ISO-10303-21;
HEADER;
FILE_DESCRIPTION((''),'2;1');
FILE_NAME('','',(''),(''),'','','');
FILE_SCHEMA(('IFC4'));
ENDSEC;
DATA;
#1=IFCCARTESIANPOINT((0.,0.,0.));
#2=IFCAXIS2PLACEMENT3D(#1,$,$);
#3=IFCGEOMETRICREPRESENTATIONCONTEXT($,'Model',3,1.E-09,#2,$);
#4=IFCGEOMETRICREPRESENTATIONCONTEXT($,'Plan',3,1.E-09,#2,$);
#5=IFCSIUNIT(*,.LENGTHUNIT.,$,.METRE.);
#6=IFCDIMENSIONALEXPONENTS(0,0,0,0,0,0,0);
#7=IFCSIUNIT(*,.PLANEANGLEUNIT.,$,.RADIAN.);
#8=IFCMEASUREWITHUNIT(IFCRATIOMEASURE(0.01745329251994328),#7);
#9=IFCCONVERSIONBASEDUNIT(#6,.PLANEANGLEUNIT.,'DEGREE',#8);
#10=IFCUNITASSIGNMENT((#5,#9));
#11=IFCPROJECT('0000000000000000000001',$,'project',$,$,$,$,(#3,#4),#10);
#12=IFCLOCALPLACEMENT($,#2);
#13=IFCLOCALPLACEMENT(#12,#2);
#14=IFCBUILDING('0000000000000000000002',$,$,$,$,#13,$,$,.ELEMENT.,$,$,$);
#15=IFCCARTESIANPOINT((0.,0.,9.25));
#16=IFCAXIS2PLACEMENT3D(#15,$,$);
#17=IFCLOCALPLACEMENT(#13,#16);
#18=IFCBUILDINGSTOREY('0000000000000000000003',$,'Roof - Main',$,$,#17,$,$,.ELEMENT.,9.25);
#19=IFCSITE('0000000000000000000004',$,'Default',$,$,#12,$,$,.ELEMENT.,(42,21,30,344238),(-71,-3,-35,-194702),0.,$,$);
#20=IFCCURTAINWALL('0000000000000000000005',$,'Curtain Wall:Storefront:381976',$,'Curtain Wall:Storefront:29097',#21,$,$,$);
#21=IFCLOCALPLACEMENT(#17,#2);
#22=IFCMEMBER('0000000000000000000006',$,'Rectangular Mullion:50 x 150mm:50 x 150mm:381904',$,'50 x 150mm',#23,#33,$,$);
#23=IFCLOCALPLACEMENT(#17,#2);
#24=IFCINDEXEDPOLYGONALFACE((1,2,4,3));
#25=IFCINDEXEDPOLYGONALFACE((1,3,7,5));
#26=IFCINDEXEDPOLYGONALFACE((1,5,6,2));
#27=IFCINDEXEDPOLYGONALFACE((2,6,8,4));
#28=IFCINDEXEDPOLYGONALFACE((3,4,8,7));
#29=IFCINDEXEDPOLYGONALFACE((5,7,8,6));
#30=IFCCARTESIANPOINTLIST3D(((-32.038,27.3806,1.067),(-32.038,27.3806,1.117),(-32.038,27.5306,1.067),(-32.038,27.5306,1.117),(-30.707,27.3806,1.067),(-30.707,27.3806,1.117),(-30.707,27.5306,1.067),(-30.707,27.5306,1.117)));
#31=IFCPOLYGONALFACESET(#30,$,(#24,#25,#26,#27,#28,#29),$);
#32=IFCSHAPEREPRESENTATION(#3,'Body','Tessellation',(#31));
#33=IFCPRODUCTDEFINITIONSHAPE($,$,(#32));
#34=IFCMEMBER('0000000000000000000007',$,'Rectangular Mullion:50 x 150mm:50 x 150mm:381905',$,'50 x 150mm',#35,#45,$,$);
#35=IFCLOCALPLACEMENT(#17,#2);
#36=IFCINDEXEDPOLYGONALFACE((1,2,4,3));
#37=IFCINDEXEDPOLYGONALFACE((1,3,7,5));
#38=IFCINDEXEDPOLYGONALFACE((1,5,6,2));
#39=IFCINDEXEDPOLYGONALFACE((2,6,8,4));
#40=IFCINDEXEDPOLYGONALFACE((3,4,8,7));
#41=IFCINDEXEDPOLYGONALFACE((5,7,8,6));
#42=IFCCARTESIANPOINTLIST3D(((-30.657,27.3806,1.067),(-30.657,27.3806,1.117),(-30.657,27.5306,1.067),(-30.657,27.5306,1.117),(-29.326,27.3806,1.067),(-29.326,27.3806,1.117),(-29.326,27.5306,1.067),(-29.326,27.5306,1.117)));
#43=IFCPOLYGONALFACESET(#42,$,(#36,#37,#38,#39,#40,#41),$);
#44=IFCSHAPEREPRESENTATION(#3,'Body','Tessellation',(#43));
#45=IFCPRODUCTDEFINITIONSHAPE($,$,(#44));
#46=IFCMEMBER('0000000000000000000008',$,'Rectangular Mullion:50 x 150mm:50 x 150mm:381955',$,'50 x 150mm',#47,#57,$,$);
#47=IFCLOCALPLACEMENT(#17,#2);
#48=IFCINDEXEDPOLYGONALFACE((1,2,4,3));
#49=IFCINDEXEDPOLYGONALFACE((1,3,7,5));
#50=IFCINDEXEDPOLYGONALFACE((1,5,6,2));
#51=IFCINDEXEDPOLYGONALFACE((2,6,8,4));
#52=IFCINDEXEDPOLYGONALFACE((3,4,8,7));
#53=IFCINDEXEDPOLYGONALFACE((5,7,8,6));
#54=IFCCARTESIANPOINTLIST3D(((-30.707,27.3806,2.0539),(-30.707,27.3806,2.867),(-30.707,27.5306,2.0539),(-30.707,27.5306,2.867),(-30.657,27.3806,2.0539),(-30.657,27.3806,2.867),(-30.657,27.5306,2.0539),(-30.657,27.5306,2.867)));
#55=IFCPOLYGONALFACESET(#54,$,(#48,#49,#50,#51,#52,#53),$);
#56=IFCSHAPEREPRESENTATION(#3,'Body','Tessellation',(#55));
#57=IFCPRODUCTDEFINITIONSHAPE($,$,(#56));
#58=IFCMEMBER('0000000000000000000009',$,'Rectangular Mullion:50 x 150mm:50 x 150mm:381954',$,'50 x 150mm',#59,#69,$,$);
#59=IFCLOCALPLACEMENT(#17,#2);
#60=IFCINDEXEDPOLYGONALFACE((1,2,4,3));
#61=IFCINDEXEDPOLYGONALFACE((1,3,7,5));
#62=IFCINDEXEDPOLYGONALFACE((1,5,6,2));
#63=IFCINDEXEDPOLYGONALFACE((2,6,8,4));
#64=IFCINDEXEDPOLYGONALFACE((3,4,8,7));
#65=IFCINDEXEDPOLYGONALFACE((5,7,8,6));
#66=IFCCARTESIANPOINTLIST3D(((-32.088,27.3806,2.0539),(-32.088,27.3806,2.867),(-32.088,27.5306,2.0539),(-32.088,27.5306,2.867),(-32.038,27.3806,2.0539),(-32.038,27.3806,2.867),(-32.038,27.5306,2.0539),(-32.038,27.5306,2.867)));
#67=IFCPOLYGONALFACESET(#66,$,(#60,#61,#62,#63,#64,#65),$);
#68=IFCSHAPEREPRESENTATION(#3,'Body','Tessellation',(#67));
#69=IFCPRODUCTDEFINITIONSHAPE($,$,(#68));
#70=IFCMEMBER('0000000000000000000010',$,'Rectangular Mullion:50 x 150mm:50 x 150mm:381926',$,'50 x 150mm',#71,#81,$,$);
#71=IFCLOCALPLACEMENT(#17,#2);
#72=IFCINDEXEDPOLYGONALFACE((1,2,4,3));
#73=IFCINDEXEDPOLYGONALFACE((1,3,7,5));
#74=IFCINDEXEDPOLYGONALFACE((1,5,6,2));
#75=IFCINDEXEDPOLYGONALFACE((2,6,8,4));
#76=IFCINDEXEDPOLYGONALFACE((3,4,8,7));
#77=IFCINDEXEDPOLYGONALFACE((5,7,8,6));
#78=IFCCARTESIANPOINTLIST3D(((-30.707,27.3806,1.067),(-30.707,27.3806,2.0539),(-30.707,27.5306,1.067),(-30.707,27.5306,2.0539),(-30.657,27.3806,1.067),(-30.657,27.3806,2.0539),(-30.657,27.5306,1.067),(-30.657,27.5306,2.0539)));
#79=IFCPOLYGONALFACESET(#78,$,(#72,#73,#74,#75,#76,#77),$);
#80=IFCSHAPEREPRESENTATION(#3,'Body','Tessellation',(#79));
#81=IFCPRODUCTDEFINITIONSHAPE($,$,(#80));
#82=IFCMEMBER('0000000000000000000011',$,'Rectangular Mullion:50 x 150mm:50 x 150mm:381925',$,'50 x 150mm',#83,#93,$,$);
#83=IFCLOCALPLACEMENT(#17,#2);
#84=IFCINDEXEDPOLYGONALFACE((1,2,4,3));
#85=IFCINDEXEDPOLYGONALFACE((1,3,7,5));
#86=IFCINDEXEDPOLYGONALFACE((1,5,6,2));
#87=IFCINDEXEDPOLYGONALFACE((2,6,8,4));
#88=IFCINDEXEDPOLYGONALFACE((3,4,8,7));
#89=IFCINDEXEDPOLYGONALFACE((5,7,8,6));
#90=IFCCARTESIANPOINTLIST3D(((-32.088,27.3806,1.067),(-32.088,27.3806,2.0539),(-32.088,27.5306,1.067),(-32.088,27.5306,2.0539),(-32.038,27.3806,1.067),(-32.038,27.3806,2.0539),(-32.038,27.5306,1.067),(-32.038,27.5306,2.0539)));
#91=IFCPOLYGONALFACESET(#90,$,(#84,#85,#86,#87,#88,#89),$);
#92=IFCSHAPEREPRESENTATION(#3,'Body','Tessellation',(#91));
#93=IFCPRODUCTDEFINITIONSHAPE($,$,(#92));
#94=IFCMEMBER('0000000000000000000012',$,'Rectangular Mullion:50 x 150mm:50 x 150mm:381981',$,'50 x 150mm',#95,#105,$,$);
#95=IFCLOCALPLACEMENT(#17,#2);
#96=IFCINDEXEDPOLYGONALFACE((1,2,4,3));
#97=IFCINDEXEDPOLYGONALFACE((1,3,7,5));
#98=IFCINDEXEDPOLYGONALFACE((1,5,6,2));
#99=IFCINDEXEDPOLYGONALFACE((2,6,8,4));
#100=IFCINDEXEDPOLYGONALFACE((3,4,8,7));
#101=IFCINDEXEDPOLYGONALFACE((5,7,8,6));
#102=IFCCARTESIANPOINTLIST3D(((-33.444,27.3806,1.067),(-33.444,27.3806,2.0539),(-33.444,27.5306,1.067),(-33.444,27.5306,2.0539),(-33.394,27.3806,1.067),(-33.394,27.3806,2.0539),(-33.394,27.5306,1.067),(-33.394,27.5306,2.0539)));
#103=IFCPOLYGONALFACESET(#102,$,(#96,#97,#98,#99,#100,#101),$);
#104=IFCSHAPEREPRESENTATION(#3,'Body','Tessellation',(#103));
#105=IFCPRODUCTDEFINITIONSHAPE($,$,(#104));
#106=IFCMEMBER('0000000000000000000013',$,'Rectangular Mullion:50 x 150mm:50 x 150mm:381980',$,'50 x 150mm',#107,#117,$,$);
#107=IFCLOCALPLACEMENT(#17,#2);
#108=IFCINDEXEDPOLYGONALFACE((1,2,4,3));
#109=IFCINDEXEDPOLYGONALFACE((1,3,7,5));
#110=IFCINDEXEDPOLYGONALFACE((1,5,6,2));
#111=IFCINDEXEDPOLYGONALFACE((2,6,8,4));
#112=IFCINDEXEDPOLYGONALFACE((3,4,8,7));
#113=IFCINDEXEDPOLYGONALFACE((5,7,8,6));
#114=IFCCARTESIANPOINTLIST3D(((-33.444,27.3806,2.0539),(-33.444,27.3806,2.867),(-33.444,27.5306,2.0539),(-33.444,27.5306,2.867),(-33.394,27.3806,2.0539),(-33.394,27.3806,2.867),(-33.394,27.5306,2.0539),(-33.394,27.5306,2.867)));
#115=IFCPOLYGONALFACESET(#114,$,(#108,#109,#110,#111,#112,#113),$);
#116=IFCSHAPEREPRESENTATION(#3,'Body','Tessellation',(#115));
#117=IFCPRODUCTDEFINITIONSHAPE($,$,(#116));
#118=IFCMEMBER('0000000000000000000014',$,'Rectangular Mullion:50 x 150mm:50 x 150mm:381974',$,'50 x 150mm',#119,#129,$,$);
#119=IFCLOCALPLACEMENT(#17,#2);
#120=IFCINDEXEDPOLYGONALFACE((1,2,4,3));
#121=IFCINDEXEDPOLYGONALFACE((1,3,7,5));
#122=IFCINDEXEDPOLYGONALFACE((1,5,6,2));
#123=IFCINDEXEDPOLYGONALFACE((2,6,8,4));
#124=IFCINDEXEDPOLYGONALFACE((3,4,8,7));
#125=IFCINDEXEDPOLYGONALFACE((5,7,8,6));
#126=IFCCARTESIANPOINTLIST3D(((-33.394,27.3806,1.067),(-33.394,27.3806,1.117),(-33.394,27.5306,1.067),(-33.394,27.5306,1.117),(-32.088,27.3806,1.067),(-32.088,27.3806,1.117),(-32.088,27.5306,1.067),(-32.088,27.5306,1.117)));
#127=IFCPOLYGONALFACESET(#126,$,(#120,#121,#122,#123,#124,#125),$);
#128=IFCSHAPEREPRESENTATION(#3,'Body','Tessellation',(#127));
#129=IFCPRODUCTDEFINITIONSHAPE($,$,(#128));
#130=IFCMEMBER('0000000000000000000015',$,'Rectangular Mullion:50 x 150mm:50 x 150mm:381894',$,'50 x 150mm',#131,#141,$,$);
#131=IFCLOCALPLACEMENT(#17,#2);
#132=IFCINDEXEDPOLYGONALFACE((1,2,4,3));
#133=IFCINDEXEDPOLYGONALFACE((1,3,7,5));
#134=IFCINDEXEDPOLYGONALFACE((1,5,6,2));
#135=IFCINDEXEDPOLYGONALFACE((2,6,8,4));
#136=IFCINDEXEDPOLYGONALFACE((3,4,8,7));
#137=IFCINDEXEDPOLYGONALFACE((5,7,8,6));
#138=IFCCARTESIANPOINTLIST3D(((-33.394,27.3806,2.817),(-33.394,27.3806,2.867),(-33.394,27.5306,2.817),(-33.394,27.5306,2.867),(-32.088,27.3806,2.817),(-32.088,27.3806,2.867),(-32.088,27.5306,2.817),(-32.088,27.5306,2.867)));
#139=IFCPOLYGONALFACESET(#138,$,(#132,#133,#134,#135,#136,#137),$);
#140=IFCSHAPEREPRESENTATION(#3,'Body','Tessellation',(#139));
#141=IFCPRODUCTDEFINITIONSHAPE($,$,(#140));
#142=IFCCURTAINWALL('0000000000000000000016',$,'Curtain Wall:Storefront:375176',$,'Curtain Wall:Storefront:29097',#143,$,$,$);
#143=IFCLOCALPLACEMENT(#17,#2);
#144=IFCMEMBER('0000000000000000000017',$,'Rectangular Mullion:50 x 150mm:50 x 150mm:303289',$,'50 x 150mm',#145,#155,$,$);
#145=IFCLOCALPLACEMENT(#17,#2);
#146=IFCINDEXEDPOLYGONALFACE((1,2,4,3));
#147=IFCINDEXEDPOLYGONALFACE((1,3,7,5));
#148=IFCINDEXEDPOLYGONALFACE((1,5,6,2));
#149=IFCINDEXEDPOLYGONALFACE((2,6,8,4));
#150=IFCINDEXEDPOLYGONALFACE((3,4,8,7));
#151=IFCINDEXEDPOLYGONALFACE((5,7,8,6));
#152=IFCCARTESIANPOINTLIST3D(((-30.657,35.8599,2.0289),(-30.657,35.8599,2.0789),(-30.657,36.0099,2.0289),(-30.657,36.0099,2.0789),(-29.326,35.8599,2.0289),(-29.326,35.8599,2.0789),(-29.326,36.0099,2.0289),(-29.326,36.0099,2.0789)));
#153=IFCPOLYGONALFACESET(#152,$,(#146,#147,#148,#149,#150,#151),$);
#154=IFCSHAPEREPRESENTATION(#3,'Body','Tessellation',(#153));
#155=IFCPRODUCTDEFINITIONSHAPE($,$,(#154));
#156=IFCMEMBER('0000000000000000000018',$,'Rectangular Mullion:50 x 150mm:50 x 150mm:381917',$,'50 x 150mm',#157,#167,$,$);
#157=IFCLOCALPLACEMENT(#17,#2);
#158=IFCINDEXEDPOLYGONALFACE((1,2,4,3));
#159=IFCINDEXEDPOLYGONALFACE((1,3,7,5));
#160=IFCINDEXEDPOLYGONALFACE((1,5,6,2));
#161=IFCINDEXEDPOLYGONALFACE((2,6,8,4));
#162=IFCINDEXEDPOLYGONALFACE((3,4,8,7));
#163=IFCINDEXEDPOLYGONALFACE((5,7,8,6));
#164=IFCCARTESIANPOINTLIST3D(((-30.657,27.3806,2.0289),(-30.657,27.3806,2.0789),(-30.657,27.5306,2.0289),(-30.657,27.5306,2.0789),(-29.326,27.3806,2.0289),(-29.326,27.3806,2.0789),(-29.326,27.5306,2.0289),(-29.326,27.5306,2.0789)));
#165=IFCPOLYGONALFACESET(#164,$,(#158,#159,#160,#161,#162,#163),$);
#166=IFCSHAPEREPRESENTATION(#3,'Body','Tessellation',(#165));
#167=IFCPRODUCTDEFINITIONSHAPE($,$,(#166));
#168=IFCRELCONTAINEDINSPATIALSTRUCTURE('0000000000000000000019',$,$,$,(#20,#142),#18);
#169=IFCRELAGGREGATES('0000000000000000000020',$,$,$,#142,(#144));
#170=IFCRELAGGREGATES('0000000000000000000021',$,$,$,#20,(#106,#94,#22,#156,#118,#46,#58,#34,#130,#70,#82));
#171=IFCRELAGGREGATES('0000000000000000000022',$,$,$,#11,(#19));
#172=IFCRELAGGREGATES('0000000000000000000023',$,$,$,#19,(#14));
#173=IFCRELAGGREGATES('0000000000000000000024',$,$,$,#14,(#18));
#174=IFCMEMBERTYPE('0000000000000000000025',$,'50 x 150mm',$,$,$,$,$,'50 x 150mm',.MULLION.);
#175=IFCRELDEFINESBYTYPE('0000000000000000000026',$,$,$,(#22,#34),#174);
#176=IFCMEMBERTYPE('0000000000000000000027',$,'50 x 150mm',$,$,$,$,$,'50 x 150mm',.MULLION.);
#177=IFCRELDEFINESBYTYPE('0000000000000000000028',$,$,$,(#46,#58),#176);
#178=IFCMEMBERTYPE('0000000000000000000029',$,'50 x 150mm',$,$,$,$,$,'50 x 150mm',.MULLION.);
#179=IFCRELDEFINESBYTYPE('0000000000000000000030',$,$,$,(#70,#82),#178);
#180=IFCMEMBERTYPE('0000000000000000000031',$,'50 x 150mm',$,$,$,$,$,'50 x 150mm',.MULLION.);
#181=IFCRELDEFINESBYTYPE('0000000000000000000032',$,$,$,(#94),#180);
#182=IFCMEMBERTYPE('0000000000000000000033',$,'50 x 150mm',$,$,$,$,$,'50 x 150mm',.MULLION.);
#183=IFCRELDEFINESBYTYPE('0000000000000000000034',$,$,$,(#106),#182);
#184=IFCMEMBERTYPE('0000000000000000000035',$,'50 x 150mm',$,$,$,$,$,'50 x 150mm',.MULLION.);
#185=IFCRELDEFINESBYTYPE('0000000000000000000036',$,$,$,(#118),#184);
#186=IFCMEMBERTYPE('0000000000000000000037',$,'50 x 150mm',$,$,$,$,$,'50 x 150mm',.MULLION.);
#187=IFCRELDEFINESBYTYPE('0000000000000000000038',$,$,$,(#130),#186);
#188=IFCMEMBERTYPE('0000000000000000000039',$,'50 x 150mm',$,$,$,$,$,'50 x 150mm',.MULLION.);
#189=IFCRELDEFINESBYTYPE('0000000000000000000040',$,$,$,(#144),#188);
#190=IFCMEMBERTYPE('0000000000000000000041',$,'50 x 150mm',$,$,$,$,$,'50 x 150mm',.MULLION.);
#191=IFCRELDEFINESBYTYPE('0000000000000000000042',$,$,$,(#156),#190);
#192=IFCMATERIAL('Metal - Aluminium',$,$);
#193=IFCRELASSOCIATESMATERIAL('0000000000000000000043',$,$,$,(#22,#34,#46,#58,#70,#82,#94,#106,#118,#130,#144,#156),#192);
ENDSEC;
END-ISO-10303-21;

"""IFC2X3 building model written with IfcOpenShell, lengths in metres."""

from ifc_helpers import new_model, entity, si_unit, converted_unit, frame, origin, origin_2d_with_axis, place, context, project, spatial, rectangle, extrude, source, transform, mapped, material, type_object, type_shapes, element, aggregate, save


model = new_model("IFC2X3")

# Units and contexts
model_context = context("Model", 3, precision=1e-09, world=origin())
plan_context = context("Plan", 3, precision=1e-09, world=origin())
ifc_project = project(units=[si_unit("LENGTHUNIT", "METRE"), converted_unit("PLANEANGLEUNIT", "DEGREE", entity("IfcRatioMeasure", 0.01745329251994328), si_unit("PLANEANGLEUNIT", "RADIAN"), dimensions=[0, 0, 0, 0, 0, 0, 0])], contexts=[model_context, plan_context])

# Site, building, storey
site_placement = place(None, origin())
site = spatial("IfcSite", under=ifc_project, at=site_placement, Name="Default", CompositionType="ELEMENT", RefLatitude=(42, 21, 30, 344238), RefLongitude=(-71, -3, -35, -194702), RefElevation=0.0)
building_placement = place(site_placement, origin())
building = spatial("IfcBuilding", under=site, at=building_placement, CompositionType="ELEMENT")
storey_placement = place(building_placement, frame((0.0, 0.0, 9.25)))
storey = spatial("IfcBuildingStorey", under=building, at=storey_placement, Name="Roof - Main", CompositionType="ELEMENT", Elevation=9.25)

# Curtain wall, members
curtain_wall_1_placement = place(storey_placement, origin())
curtain_wall_1 = element("IfcCurtainWall", 1, at=curtain_wall_1_placement, inside=storey, Name="Curtain Wall:Storefront:381976", ObjectType="Curtain Wall:Storefront:29097")
ifc_material_1 = material(Name="Metal - Aluminium")
member_type_1 = type_object("IfcMemberType", Name="50 x 150mm", ElementType="50 x 150mm", PredefinedType="MULLION")
shared_shape_1 = source(origin(), model_context, "Body", "SweptSolid", [
    extrude(rectangle(XDim=0.05, YDim=0.15, at=origin_2d_with_axis()), frame((-0.025, 0.0, -1.331), z_axis=(0.0, 0.0, 1.0), x_axis=(-1.0, 0.0, 0.0)), (0.0, 0.0, 1.0), 1.331),
])
type_shapes(member_type_1, [shared_shape_1])
member_1_placement = place(storey_placement, frame((-32.038, 27.4556, 1.067), z_axis=(-1.0, 0.0, 0.0), x_axis=(0.0, 0.0, -1.0)))
member_1 = element("IfcMember", 2, at=member_1_placement, type_object=member_type_1, material=ifc_material_1, Name="Rectangular Mullion:50 x 150mm:50 x 150mm:381904", ObjectType="50 x 150mm", context=model_context, shape_type="MappedRepresentation", body=[
    mapped(shared_shape_1, transform((0.0, 0.0, 0.0), scale=1.0)),
])
member_2_placement = place(storey_placement, frame((-30.657, 27.4556, 1.067), z_axis=(-1.0, 0.0, 0.0), x_axis=(0.0, 0.0, -1.0)))
member_2 = element("IfcMember", 3, at=member_2_placement, type_object=member_type_1, material=ifc_material_1, Name="Rectangular Mullion:50 x 150mm:50 x 150mm:381905", ObjectType="50 x 150mm", context=model_context, shape_type="MappedRepresentation", body=[
    mapped(shared_shape_1, transform((0.0, 0.0, 0.0), scale=1.0)),
])
member_type_2 = type_object("IfcMemberType", Name="50 x 150mm", ElementType="50 x 150mm", PredefinedType="MULLION")
shared_shape_2 = source(origin(), model_context, "Body", "SweptSolid", [
    extrude(rectangle(XDim=0.05, YDim=0.15, at=origin_2d_with_axis()), frame((0.0, 0.0, -0.8131), z_axis=(0.0, 0.0, 1.0), x_axis=(-1.0, 0.0, 0.0)), (0.0, 0.0, 1.0), 0.8131),
])
type_shapes(member_type_2, [shared_shape_2])
member_3_placement = place(storey_placement, frame((-30.682, 27.4556, 2.0539), z_axis=(0.0, 0.0, -1.0), x_axis=(1.0, 0.0, 0.0)))
member_3 = element("IfcMember", 4, at=member_3_placement, type_object=member_type_2, material=ifc_material_1, Name="Rectangular Mullion:50 x 150mm:50 x 150mm:381955", ObjectType="50 x 150mm", context=model_context, shape_type="MappedRepresentation", body=[
    mapped(shared_shape_2, transform((0.0, 0.0, 0.0), scale=1.0)),
])
member_4_placement = place(storey_placement, frame((-32.063, 27.4556, 2.0539), z_axis=(0.0, 0.0, -1.0), x_axis=(1.0, 0.0, 0.0)))
member_4 = element("IfcMember", 5, at=member_4_placement, type_object=member_type_2, material=ifc_material_1, Name="Rectangular Mullion:50 x 150mm:50 x 150mm:381954", ObjectType="50 x 150mm", context=model_context, shape_type="MappedRepresentation", body=[
    mapped(shared_shape_2, transform((0.0, 0.0, 0.0), scale=1.0)),
])
member_type_3 = type_object("IfcMemberType", Name="50 x 150mm", ElementType="50 x 150mm", PredefinedType="MULLION")
shared_shape_3 = source(origin(), model_context, "Body", "SweptSolid", [
    extrude(rectangle(XDim=0.05, YDim=0.15, at=origin_2d_with_axis()), frame((0.0, 0.0, -0.9869), z_axis=(0.0, 0.0, 1.0), x_axis=(-1.0, 0.0, 0.0)), (0.0, 0.0, 1.0), 0.9869),
])
type_shapes(member_type_3, [shared_shape_3])
member_5_placement = place(storey_placement, frame((-30.682, 27.4556, 1.067), z_axis=(0.0, 0.0, -1.0), x_axis=(1.0, 0.0, 0.0)))
member_5 = element("IfcMember", 6, at=member_5_placement, type_object=member_type_3, material=ifc_material_1, Name="Rectangular Mullion:50 x 150mm:50 x 150mm:381926", ObjectType="50 x 150mm", context=model_context, shape_type="MappedRepresentation", body=[
    mapped(shared_shape_3, transform((0.0, 0.0, 0.0), scale=1.0)),
])
member_6_placement = place(storey_placement, frame((-32.063, 27.4556, 1.067), z_axis=(0.0, 0.0, -1.0), x_axis=(1.0, 0.0, 0.0)))
member_6 = element("IfcMember", 7, at=member_6_placement, type_object=member_type_3, material=ifc_material_1, Name="Rectangular Mullion:50 x 150mm:50 x 150mm:381925", ObjectType="50 x 150mm", context=model_context, shape_type="MappedRepresentation", body=[
    mapped(shared_shape_3, transform((0.0, 0.0, 0.0), scale=1.0)),
])
member_type_4 = type_object("IfcMemberType", Name="50 x 150mm", ElementType="50 x 150mm", PredefinedType="MULLION")
shared_shape_4 = source(origin(), model_context, "Body", "SweptSolid", [
    extrude(rectangle(XDim=0.05, YDim=0.15, at=origin_2d_with_axis()), frame((-0.025, 0.0, -0.9869), z_axis=(0.0, 0.0, 1.0), x_axis=(-1.0, 0.0, 0.0)), (0.0, 0.0, 1.0), 0.9869),
])
type_shapes(member_type_4, [shared_shape_4])
member_7_placement = place(storey_placement, frame((-33.444, 27.4556, 2.0539), z_axis=(0.0, 0.0, 1.0), x_axis=(-1.0, 0.0, 0.0)))
member_7 = element("IfcMember", 8, at=member_7_placement, type_object=member_type_4, material=ifc_material_1, Name="Rectangular Mullion:50 x 150mm:50 x 150mm:381981", ObjectType="50 x 150mm", context=model_context, shape_type="MappedRepresentation", body=[
    mapped(shared_shape_4, transform((0.0, 0.0, 0.0), scale=1.0)),
])
member_type_5 = type_object("IfcMemberType", Name="50 x 150mm", ElementType="50 x 150mm", PredefinedType="MULLION")
shared_shape_5 = source(origin(), model_context, "Body", "SweptSolid", [
    extrude(rectangle(XDim=0.05, YDim=0.15, at=origin_2d_with_axis()), frame((-0.025, 0.0, -0.8131), z_axis=(0.0, 0.0, 1.0), x_axis=(-1.0, 0.0, 0.0)), (0.0, 0.0, 1.0), 0.8131),
])
type_shapes(member_type_5, [shared_shape_5])
member_8_placement = place(storey_placement, frame((-33.444, 27.4556, 2.867), z_axis=(0.0, 0.0, 1.0), x_axis=(-1.0, 0.0, 0.0)))
member_8 = element("IfcMember", 9, at=member_8_placement, type_object=member_type_5, material=ifc_material_1, Name="Rectangular Mullion:50 x 150mm:50 x 150mm:381980", ObjectType="50 x 150mm", context=model_context, shape_type="MappedRepresentation", body=[
    mapped(shared_shape_5, transform((0.0, 0.0, 0.0), scale=1.0)),
])
member_type_6 = type_object("IfcMemberType", Name="50 x 150mm", ElementType="50 x 150mm", PredefinedType="MULLION")
shared_shape_6 = source(origin(), model_context, "Body", "SweptSolid", [
    extrude(rectangle(XDim=0.05, YDim=0.15, at=origin_2d_with_axis()), frame((-0.025, 0.0, -1.306), z_axis=(0.0, 0.0, 1.0), x_axis=(-1.0, 0.0, 0.0)), (0.0, 0.0, 1.0), 1.306),
])
type_shapes(member_type_6, [shared_shape_6])
member_9_placement = place(storey_placement, frame((-33.394, 27.4556, 1.067), z_axis=(-1.0, 0.0, 0.0), x_axis=(0.0, 0.0, -1.0)))
member_9 = element("IfcMember", 10, at=member_9_placement, type_object=member_type_6, material=ifc_material_1, Name="Rectangular Mullion:50 x 150mm:50 x 150mm:381974", ObjectType="50 x 150mm", context=model_context, shape_type="MappedRepresentation", body=[
    mapped(shared_shape_6, transform((0.0, 0.0, 0.0), scale=1.0)),
])
member_type_7 = type_object("IfcMemberType", Name="50 x 150mm", ElementType="50 x 150mm", PredefinedType="MULLION")
shared_shape_7 = source(origin(), model_context, "Body", "SweptSolid", [
    extrude(rectangle(XDim=0.05, YDim=0.15, at=origin_2d_with_axis()), frame((-0.025, 0.0, -1.306), z_axis=(0.0, 0.0, 1.0), x_axis=(-1.0, 0.0, 0.0)), (0.0, 0.0, 1.0), 1.306),
])
type_shapes(member_type_7, [shared_shape_7])
member_10_placement = place(storey_placement, frame((-32.088, 27.4556, 2.867), z_axis=(1.0, 0.0, 0.0), x_axis=(0.0, 0.0, 1.0)))
member_10 = element("IfcMember", 11, at=member_10_placement, type_object=member_type_7, material=ifc_material_1, Name="Rectangular Mullion:50 x 150mm:50 x 150mm:381894", ObjectType="50 x 150mm", context=model_context, shape_type="MappedRepresentation", body=[
    mapped(shared_shape_7, transform((0.0, 0.0, 0.0), scale=1.0)),
])

# Curtain wall, member
curtain_wall_2_placement = place(storey_placement, origin())
curtain_wall_2 = element("IfcCurtainWall", 12, at=curtain_wall_2_placement, inside=storey, Name="Curtain Wall:Storefront:375176", ObjectType="Curtain Wall:Storefront:29097")
member_type_8 = type_object("IfcMemberType", Name="50 x 150mm", ElementType="50 x 150mm", PredefinedType="MULLION")
shared_shape_8 = source(origin(), model_context, "Body", "SweptSolid", [
    extrude(rectangle(XDim=0.05, YDim=0.15, at=origin_2d_with_axis()), frame((0.0, 0.0, -1.331), z_axis=(0.0, 0.0, 1.0), x_axis=(-1.0, 0.0, 0.0)), (0.0, 0.0, 1.0), 1.331),
])
type_shapes(member_type_8, [shared_shape_8])
member_11_placement = place(storey_placement, frame((-29.326, 35.9349, 2.0539), z_axis=(1.0, 0.0, 0.0), x_axis=(0.0, 0.0, 1.0)))
member_11 = element("IfcMember", 13, at=member_11_placement, type_object=member_type_8, material=ifc_material_1, Name="Rectangular Mullion:50 x 150mm:50 x 150mm:303289", ObjectType="50 x 150mm", context=model_context, shape_type="MappedRepresentation", body=[
    mapped(shared_shape_8, transform((0.0, 0.0, 0.0), scale=1.0)),
])
aggregate(curtain_wall_2, [member_11])

# Member
member_type_9 = type_object("IfcMemberType", Name="50 x 150mm", ElementType="50 x 150mm", PredefinedType="MULLION")
shared_shape_9 = source(origin(), model_context, "Body", "SweptSolid", [
    extrude(rectangle(XDim=0.05, YDim=0.15, at=origin_2d_with_axis()), frame((0.0, 0.0, -1.331), z_axis=(0.0, 0.0, 1.0), x_axis=(-1.0, 0.0, 0.0)), (0.0, 0.0, 1.0), 1.331),
])
type_shapes(member_type_9, [shared_shape_9])
member_12_placement = place(storey_placement, frame((-29.326, 27.4556, 2.0539), z_axis=(1.0, 0.0, 0.0), x_axis=(0.0, 0.0, 1.0)))
member_12 = element("IfcMember", 14, at=member_12_placement, type_object=member_type_9, material=ifc_material_1, Name="Rectangular Mullion:50 x 150mm:50 x 150mm:381917", ObjectType="50 x 150mm", context=model_context, shape_type="MappedRepresentation", body=[
    mapped(shared_shape_9, transform((0.0, 0.0, 0.0), scale=1.0)),
])

aggregate(curtain_wall_1, [member_8, member_7, member_1, member_12, member_9, member_3, member_4, member_2, member_10, member_5, member_6])

save(model, "model.ifc")
